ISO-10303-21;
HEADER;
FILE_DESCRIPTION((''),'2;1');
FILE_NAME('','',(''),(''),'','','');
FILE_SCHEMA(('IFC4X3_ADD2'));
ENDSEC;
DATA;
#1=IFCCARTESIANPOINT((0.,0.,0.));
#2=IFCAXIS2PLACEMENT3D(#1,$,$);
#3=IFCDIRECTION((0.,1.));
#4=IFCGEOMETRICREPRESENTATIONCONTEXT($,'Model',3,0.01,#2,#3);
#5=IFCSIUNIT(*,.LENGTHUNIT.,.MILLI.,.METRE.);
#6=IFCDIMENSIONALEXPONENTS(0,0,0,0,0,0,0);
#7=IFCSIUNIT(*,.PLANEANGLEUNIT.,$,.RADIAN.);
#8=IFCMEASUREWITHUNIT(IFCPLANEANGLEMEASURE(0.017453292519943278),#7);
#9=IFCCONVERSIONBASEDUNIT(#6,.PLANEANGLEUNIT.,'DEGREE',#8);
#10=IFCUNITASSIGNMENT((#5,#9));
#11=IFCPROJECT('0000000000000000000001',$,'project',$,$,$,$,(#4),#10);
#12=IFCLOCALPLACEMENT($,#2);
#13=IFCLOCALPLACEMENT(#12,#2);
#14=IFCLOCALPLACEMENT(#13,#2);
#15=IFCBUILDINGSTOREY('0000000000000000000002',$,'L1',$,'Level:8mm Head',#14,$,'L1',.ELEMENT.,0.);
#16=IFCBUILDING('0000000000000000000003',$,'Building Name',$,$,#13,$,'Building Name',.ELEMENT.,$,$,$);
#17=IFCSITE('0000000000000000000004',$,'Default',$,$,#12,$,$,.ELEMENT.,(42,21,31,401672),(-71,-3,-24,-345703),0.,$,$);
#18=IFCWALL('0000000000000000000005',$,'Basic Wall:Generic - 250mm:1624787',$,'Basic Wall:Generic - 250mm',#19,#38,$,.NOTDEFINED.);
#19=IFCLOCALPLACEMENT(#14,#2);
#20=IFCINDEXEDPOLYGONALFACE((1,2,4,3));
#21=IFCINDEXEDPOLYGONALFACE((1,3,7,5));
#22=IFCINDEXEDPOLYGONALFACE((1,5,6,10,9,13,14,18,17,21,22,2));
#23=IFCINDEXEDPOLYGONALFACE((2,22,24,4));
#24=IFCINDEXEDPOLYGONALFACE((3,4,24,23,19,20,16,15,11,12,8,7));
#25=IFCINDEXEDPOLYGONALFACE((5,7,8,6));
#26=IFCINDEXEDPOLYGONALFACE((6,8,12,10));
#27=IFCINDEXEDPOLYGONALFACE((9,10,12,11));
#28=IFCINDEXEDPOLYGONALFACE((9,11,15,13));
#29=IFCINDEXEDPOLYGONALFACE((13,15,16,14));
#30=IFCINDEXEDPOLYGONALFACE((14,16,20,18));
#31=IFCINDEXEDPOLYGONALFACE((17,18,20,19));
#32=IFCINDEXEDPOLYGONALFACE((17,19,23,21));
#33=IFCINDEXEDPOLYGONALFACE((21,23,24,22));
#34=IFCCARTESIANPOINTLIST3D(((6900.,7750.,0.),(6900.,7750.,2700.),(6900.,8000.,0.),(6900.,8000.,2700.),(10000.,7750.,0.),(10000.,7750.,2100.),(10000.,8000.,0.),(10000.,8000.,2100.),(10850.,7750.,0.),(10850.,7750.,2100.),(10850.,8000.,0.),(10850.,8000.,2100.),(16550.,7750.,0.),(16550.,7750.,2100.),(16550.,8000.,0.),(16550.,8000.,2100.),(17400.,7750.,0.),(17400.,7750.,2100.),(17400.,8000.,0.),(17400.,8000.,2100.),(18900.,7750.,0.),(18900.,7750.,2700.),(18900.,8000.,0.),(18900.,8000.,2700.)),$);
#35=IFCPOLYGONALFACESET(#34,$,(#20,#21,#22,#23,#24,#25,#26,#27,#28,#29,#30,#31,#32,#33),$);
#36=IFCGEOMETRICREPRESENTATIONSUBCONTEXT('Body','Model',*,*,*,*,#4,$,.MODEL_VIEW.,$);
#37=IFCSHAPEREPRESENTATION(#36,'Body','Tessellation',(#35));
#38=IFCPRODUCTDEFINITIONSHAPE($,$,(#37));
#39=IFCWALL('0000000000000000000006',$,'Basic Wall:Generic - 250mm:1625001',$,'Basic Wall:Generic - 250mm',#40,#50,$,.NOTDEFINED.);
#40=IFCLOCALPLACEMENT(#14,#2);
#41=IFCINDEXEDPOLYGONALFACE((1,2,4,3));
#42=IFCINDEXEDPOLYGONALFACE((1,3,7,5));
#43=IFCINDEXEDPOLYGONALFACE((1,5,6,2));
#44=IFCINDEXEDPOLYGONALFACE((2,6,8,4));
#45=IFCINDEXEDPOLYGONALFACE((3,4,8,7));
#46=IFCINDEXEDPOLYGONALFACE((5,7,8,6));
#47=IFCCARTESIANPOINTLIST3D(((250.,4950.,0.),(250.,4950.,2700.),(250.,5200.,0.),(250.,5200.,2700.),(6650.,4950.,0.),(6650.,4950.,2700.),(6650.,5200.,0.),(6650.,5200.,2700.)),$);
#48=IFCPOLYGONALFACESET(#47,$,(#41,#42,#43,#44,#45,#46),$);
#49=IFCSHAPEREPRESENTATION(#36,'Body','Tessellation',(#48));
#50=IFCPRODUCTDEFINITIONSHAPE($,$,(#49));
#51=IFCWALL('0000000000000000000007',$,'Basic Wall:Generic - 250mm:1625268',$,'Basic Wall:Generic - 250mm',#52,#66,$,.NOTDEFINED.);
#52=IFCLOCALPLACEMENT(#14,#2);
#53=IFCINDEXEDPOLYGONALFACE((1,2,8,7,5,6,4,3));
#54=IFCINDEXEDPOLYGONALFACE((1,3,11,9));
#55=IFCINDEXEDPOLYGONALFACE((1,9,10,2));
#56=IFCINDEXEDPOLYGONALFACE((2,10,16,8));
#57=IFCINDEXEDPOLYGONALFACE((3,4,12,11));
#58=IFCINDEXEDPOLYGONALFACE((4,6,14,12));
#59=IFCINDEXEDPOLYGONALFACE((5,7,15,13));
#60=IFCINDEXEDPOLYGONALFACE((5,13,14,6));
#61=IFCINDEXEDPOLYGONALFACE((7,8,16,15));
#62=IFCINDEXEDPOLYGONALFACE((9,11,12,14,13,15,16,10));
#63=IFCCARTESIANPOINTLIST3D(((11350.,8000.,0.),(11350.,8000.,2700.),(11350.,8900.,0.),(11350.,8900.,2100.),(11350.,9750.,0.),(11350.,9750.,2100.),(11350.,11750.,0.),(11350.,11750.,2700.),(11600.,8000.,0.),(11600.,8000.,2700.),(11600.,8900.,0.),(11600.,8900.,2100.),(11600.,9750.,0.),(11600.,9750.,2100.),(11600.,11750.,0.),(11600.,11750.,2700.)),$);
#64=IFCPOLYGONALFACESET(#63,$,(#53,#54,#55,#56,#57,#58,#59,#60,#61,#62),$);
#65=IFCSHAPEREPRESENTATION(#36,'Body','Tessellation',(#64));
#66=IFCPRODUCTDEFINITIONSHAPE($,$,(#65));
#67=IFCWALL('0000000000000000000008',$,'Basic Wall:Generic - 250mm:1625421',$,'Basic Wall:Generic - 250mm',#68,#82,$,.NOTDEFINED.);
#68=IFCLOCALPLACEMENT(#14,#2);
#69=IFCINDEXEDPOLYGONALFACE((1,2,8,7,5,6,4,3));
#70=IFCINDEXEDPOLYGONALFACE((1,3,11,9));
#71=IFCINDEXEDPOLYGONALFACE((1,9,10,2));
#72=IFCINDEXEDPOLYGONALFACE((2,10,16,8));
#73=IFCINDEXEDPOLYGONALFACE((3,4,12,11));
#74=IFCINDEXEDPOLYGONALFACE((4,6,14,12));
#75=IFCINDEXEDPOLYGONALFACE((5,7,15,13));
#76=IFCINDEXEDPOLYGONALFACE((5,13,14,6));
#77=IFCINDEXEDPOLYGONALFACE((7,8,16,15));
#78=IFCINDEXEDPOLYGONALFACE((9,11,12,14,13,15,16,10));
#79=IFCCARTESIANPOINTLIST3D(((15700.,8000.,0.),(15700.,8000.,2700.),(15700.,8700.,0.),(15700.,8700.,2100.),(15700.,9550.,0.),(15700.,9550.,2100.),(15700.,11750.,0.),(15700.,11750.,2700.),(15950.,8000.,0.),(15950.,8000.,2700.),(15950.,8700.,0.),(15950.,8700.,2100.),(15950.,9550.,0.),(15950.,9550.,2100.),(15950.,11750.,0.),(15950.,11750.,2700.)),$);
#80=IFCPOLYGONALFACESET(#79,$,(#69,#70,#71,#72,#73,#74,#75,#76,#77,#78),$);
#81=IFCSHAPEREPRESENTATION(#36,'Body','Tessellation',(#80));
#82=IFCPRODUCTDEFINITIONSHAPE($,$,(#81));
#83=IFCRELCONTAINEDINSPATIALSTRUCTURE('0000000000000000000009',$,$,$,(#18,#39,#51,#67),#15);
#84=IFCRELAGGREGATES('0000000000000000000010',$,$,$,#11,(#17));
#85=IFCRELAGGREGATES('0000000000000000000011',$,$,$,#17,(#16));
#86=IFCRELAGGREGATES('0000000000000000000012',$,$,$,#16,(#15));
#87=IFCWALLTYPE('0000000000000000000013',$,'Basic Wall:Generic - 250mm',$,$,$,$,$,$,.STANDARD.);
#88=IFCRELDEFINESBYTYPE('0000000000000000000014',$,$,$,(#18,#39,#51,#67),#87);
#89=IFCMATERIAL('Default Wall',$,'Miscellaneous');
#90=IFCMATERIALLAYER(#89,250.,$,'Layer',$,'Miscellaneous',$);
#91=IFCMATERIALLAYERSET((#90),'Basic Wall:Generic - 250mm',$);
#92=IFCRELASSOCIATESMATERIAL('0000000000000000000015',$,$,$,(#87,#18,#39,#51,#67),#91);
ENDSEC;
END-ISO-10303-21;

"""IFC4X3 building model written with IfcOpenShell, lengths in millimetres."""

from ifc_helpers import new_model, entity, si_unit, converted_unit, direction, frame, frame_2d, origin, place, context, subcontext, project, spatial, rectangle, extrude, material, layer, layer_set, type_object, element, save


model = new_model("IFC4X3")

# Units and contexts
model_context = context("Model", 3, precision=0.01, world=origin(), true_north=direction((0.0, 1.0)))
body_context = subcontext(model_context, "Body", "Model", "MODEL_VIEW")
ifc_project = project(units=[si_unit("LENGTHUNIT", "METRE", prefix="MILLI"), converted_unit("PLANEANGLEUNIT", "DEGREE", entity("IfcPlaneAngleMeasure", 0.017453292519943278), si_unit("PLANEANGLEUNIT", "RADIAN"), dimensions=[0, 0, 0, 0, 0, 0, 0])], contexts=[model_context])

# Site, building, storey
site_placement = place(None, origin())
site = spatial("IfcSite", under=ifc_project, at=site_placement, Name="Default", CompositionType="ELEMENT", RefLatitude=(42, 21, 31, 401672), RefLongitude=(-71, -3, -24, -345703), RefElevation=0.0)
building_placement = place(site_placement, origin())
building = spatial("IfcBuilding", under=site, at=building_placement, Name="Building Name", LongName="Building Name", CompositionType="ELEMENT")
storey_placement = place(building_placement, origin())
storey = spatial("IfcBuildingStorey", under=building, at=storey_placement, Name="L1", ObjectType="Level:8mm Head", LongName="L1", CompositionType="ELEMENT", Elevation=0.0)

# Shared definitions
ifc_material_1 = material(Name="Default Wall", Category="Miscellaneous")
ifc_layer = layer(ifc_material_1, 250.0, Name="Layer", Category="Miscellaneous")
ifc_layer_set = layer_set([ifc_layer], Name="Basic Wall:Generic - 250mm")
wall_type = type_object("IfcWallType", Name="Basic Wall:Generic - 250mm", PredefinedType="STANDARD", material=ifc_layer_set)

# Wall, openings
wall_1_placement = place(storey_placement, frame((6900.0, 7875.0, 0.0)))
wall_1 = element("IfcWall", 1, at=wall_1_placement, inside=storey, type_object=wall_type, material=ifc_layer_set, Name="Basic Wall:Generic - 250mm:1624787", ObjectType="Basic Wall:Generic - 250mm", PredefinedType="NOTDEFINED", context=body_context, shape_type="SweptSolid", body=[
    extrude(rectangle(XDim=12000.0, YDim=250.0, at=frame_2d((6000.0, 0.0), x_axis=(1.0, 0.0))), origin(), (0.0, 0.0, 1.0), 2700.0),
])
opening_1_placement = place(wall_1_placement, frame((3100.0, -125.0, 0.0)))
element("IfcOpeningElement", 2, at=opening_1_placement, cuts=wall_1, PredefinedType="OPENING", context=body_context, shape_type="SweptSolid", body=[
    extrude(rectangle(XDim=2100.0, YDim=850.0, at=frame_2d((1050.0, 425.0), x_axis=(1.0, 0.0))), frame((0.0, 0.0, 0.0), z_axis=(0.0, 1.0, 0.0), x_axis=(0.0, 0.0, 1.0)), (0.0, 0.0, 1.0), 250.0),
])
opening_2_placement = place(wall_1_placement, frame((9650.0, -125.0, 0.0)))
element("IfcOpeningElement", 3, at=opening_2_placement, cuts=wall_1, PredefinedType="OPENING", context=body_context, shape_type="SweptSolid", body=[
    extrude(rectangle(XDim=2100.0, YDim=850.0, at=frame_2d((1050.0, 425.0), x_axis=(1.0, 0.0))), frame((0.0, 0.0, 0.0), z_axis=(0.0, 1.0, 0.0), x_axis=(0.0, 0.0, 1.0)), (0.0, 0.0, 1.0), 250.0),
])

# Wall
wall_2_placement = place(storey_placement, frame((6650.0, 5075.0, 0.0), z_axis=(0.0, 0.0, 1.0), x_axis=(-1.0, 0.0, 0.0)))
element("IfcWall", 4, at=wall_2_placement, inside=storey, type_object=wall_type, material=ifc_layer_set, Name="Basic Wall:Generic - 250mm:1625001", ObjectType="Basic Wall:Generic - 250mm", PredefinedType="NOTDEFINED", context=body_context, shape_type="SweptSolid", body=[
    extrude(rectangle(XDim=6400.0, YDim=250.0, at=frame_2d((3200.0, 0.0), x_axis=(-1.0, 0.0))), origin(), (0.0, 0.0, 1.0), 2700.0),
])

# Walls, openings
wall_3_placement = place(storey_placement, frame((11475.0, 8000.0, 0.0), z_axis=(0.0, 0.0, 1.0), x_axis=(0.0, 1.0, 0.0)))
wall_3 = element("IfcWall", 5, at=wall_3_placement, inside=storey, type_object=wall_type, material=ifc_layer_set, Name="Basic Wall:Generic - 250mm:1625268", ObjectType="Basic Wall:Generic - 250mm", PredefinedType="NOTDEFINED", context=body_context, shape_type="SweptSolid", body=[
    extrude(rectangle(XDim=3750.0, YDim=250.0, at=frame_2d((1875.0, 0.0), x_axis=(1.0, 0.0))), origin(), (0.0, 0.0, 1.0), 2700.0),
])
opening_3_placement = place(wall_3_placement, frame((1750.0, 125.0, 0.0)))
element("IfcOpeningElement", 6, at=opening_3_placement, cuts=wall_3, PredefinedType="OPENING", context=body_context, shape_type="SweptSolid", body=[
    extrude(rectangle(XDim=2100.0, YDim=850.0, at=frame_2d((1050.0, 425.0), x_axis=(1.0, 0.0))), frame((0.0, 0.0, 0.0), z_axis=(0.0, -1.0, 0.0), x_axis=(0.0, 0.0, 1.0)), (0.0, 0.0, 1.0), 250.0),
])
wall_4_placement = place(storey_placement, frame((15825.0, 8000.0, 0.0), z_axis=(0.0, 0.0, 1.0), x_axis=(0.0, 1.0, 0.0)))
wall_4 = element("IfcWall", 7, at=wall_4_placement, inside=storey, type_object=wall_type, material=ifc_layer_set, Name="Basic Wall:Generic - 250mm:1625421", ObjectType="Basic Wall:Generic - 250mm", PredefinedType="NOTDEFINED", context=body_context, shape_type="SweptSolid", body=[
    extrude(rectangle(XDim=3750.0, YDim=250.0, at=frame_2d((1875.0, 0.0), x_axis=(1.0, 0.0))), origin(), (0.0, 0.0, 1.0), 2700.0),
])
opening_4_placement = place(wall_4_placement, frame((700.0, -125.0, 0.0)))
element("IfcOpeningElement", 8, at=opening_4_placement, cuts=wall_4, PredefinedType="OPENING", context=body_context, shape_type="SweptSolid", body=[
    extrude(rectangle(XDim=2100.0, YDim=850.0, at=frame_2d((1050.0, 425.0), x_axis=(1.0, 0.0))), frame((0.0, 0.0, 0.0), z_axis=(0.0, 1.0, 0.0), x_axis=(0.0, 0.0, 1.0)), (0.0, 0.0, 1.0), 250.0),
])

save(model, "model.ifc")
